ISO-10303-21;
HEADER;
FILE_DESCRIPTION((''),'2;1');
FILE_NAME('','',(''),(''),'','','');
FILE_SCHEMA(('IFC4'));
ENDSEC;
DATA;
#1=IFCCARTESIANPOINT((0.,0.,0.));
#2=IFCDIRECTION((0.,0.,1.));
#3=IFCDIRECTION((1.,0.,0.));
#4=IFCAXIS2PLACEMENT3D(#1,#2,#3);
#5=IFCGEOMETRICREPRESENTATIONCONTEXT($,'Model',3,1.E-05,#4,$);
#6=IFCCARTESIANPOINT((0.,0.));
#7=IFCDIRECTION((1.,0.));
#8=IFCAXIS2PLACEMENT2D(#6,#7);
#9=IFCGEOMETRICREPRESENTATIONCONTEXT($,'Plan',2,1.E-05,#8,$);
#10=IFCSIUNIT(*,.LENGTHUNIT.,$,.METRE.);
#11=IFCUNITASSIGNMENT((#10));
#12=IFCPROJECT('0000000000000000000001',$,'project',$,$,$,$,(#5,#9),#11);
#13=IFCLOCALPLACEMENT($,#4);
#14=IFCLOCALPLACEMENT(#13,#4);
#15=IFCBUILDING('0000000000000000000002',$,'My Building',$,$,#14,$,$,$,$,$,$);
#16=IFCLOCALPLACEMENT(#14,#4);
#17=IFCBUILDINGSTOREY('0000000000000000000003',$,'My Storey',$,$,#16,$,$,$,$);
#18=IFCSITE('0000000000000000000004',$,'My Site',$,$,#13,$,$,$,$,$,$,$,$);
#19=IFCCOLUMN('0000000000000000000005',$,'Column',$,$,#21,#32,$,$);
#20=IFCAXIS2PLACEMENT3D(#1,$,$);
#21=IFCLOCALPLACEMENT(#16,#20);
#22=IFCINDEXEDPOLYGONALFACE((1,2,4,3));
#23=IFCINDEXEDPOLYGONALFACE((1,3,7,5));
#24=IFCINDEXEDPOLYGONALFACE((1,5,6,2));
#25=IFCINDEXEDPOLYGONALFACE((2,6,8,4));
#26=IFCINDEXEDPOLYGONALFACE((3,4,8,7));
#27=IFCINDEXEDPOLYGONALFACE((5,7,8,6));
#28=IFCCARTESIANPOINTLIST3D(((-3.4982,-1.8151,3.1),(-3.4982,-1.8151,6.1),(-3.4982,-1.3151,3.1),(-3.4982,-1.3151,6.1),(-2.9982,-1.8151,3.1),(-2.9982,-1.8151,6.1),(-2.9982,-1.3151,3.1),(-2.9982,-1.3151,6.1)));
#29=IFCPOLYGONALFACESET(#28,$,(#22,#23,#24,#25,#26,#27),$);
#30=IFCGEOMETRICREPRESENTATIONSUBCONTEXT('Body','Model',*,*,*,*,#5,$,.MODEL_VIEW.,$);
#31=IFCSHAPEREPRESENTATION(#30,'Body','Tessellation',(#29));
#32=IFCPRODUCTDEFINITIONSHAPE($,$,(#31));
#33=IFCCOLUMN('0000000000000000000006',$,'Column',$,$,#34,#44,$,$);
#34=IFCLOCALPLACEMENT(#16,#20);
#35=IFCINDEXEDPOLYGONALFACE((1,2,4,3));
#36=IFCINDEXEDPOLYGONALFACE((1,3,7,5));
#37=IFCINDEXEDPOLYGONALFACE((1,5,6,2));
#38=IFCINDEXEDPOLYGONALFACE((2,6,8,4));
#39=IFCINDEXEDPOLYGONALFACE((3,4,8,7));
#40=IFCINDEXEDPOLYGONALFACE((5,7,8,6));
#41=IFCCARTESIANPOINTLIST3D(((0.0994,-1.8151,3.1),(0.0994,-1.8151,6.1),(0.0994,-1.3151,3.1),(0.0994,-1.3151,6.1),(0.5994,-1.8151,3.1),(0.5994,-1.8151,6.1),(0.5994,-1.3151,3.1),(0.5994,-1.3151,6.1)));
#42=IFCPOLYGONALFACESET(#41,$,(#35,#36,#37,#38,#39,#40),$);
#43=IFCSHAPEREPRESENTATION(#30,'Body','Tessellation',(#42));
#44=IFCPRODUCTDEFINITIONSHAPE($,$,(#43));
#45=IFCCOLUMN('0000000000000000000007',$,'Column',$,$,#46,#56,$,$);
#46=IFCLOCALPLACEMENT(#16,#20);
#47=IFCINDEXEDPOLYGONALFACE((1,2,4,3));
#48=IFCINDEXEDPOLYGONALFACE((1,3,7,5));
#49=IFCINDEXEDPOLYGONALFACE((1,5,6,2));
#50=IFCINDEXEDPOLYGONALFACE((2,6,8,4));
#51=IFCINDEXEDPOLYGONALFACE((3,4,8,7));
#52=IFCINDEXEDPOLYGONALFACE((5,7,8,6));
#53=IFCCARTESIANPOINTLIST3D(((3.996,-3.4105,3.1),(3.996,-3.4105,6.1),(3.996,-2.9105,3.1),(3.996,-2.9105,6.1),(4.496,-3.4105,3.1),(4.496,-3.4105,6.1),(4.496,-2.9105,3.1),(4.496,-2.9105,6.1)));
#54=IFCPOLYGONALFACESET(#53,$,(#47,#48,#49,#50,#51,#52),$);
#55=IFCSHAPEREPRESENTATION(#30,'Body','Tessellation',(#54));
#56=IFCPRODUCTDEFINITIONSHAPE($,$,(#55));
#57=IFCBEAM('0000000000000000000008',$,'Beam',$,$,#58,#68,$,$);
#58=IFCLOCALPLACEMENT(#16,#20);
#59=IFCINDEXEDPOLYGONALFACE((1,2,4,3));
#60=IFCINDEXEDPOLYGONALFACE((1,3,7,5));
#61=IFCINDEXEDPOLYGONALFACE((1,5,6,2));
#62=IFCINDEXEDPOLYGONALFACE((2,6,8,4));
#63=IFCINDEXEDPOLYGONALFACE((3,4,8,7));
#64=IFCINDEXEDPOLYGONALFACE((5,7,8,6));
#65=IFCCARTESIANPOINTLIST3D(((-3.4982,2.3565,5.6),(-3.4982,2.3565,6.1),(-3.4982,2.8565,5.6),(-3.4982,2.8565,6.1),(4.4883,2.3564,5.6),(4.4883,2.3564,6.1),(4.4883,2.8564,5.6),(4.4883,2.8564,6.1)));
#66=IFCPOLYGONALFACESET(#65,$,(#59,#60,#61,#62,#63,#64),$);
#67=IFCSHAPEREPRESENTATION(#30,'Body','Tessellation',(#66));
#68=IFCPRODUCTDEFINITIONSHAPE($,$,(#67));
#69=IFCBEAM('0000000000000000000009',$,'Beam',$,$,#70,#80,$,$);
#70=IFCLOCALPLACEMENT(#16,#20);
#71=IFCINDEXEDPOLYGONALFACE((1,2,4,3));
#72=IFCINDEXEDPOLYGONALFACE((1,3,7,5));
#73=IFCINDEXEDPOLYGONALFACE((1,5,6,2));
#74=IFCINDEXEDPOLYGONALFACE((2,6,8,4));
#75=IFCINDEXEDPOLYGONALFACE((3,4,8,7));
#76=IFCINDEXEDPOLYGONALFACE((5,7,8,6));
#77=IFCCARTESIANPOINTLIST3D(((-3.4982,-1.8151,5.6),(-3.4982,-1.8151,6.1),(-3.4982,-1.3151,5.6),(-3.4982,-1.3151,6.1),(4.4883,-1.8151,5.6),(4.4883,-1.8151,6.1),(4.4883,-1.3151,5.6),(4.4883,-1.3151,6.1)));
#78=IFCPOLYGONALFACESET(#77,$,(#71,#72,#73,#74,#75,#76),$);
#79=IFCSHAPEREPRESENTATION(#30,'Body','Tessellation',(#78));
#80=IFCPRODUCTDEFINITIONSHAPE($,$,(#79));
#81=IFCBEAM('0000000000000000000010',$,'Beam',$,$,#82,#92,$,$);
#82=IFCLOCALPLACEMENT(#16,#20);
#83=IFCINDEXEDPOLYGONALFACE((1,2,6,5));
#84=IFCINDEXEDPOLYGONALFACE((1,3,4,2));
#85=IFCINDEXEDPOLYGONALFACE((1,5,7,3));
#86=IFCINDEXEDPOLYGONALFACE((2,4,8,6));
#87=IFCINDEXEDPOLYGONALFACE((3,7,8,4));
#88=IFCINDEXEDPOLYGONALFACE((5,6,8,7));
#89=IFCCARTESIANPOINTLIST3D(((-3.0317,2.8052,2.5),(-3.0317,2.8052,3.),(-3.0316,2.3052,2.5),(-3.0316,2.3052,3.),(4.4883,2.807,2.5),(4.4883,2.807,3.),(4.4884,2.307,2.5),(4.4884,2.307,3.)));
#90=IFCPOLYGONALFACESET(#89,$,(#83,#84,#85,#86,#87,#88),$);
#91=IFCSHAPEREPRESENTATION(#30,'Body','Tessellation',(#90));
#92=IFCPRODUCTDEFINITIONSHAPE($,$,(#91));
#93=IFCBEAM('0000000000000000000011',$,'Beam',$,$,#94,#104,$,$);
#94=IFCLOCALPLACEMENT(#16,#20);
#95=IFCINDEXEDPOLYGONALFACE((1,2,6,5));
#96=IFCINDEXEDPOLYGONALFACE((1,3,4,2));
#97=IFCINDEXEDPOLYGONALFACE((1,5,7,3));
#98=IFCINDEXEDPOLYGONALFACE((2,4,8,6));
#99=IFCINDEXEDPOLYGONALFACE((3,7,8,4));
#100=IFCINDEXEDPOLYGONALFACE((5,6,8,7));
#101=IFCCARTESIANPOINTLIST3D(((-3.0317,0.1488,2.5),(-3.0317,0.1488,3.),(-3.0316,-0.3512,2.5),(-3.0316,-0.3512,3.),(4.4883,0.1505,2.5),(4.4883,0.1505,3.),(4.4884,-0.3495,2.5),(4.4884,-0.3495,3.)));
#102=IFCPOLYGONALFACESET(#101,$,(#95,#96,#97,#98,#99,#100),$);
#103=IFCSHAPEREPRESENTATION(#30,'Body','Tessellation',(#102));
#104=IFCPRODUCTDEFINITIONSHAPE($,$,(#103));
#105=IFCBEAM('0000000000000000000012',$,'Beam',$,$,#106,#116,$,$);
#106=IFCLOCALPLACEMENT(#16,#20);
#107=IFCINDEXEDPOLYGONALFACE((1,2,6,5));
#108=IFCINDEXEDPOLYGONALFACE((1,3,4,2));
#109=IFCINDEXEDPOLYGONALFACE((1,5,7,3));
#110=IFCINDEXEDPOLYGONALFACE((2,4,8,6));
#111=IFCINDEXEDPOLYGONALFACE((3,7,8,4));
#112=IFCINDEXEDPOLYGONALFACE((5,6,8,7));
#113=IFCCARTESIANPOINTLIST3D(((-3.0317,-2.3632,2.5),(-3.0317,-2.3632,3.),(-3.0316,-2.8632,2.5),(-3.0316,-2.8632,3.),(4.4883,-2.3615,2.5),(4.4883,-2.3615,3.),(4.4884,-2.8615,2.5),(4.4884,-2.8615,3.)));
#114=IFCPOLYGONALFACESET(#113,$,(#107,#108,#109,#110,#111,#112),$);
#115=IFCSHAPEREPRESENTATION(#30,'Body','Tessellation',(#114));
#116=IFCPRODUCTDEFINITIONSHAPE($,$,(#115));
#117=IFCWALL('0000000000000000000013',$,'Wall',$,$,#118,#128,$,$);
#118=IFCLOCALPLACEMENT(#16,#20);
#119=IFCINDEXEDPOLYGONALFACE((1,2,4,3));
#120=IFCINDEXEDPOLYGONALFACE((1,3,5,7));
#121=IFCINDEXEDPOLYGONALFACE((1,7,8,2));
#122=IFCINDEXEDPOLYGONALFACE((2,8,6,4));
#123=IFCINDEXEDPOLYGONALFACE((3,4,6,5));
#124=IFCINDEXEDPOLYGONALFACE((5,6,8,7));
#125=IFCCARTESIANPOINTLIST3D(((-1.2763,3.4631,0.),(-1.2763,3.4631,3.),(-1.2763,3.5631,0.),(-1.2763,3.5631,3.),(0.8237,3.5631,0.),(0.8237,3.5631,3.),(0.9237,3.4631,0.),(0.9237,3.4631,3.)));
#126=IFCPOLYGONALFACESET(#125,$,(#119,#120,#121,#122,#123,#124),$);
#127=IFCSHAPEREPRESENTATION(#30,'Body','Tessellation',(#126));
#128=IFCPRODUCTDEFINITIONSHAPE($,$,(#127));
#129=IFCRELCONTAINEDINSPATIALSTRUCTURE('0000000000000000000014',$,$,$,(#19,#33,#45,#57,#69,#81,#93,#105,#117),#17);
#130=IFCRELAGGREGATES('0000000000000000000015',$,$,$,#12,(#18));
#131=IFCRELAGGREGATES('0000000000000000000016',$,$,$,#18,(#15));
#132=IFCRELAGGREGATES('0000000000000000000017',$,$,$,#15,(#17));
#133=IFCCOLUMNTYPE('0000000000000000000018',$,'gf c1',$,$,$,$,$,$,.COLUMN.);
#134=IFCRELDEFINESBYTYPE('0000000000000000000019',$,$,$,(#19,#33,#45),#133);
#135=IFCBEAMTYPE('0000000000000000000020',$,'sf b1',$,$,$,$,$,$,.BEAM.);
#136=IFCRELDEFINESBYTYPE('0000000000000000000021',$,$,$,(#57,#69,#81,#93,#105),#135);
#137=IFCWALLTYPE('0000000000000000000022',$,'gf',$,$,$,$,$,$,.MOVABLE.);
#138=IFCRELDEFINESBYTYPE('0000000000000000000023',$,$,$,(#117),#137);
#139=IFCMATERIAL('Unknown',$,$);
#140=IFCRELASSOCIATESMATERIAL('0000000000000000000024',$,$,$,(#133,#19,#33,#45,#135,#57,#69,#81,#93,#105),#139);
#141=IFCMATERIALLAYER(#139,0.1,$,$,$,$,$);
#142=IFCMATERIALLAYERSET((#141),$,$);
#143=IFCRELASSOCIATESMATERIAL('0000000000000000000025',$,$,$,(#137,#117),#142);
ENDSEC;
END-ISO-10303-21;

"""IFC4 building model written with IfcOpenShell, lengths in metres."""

from ifc_helpers import new_model, si_unit, frame, origin_with_axes, origin_2d_with_axis, place, context, subcontext, project, spatial, line, indexed_curve, rectangle, outline, extrude, material, layer, layer_set, layer_usage, material_profile, profile_set, profile_usage, type_object, element, save


model = new_model("IFC4")

# Units and contexts
model_context = context("Model", 3, precision=1e-05, world=origin_with_axes())
plan_context = context("Plan", 2, precision=1e-05, world=origin_2d_with_axis())
body_context = subcontext(model_context, "Body", "Model", "MODEL_VIEW")
ifc_project = project(units=[si_unit("LENGTHUNIT", "METRE")], contexts=[model_context, plan_context])

# Site, building, storey
site_placement = place(None, origin_with_axes())
site = spatial("IfcSite", under=ifc_project, at=site_placement, Name="My Site")
building_placement = place(site_placement, origin_with_axes())
building = spatial("IfcBuilding", under=site, at=building_placement, Name="My Building")
storey_placement = place(building_placement, origin_with_axes())
storey = spatial("IfcBuildingStorey", under=building, at=storey_placement, Name="My Storey")

# Columns
ifc_material = material(Name="Unknown")
ifc_material_profile_1 = material_profile(ifc_material, rectangle(XDim=0.5, YDim=0.5))
ifc_profile_set_1 = profile_set([ifc_material_profile_1])
column_type_1 = type_object("IfcColumnType", Name="gf c1", PredefinedType="COLUMN", material=ifc_profile_set_1)
ifc_profile_usage_1 = profile_usage(ifc_profile_set_1, cardinal=5)
column_1_placement = place(storey_placement, frame((-3.2482, -1.5651, 3.1), z_axis=(0.0, 0.0, 1.0), x_axis=(1.0, 0.0, 0.0)))
element("IfcColumn", 1, at=column_1_placement, inside=storey, type_object=column_type_1, material=ifc_profile_usage_1, Name="Column", context=body_context, shape_type="SweptSolid", body=[
    extrude(rectangle(XDim=0.5, YDim=0.5), origin_with_axes(), (0.0, 0.0, 1.0), 3.0),
])
ifc_profile_usage_2 = profile_usage(ifc_profile_set_1, cardinal=5)
column_2_placement = place(storey_placement, frame((0.3494, -1.5651, 3.1), z_axis=(0.0, 0.0, 1.0), x_axis=(1.0, 0.0, 0.0)))
element("IfcColumn", 2, at=column_2_placement, inside=storey, type_object=column_type_1, material=ifc_profile_usage_2, Name="Column", context=body_context, shape_type="SweptSolid", body=[
    extrude(rectangle(XDim=0.5, YDim=0.5), origin_with_axes(), (0.0, 0.0, 1.0), 3.0),
])
ifc_profile_usage_3 = profile_usage(ifc_profile_set_1, cardinal=5)
column_3_placement = place(storey_placement, frame((4.246, -3.1605, 3.1), z_axis=(0.0, 0.0, 1.0), x_axis=(1.0, 0.0, 0.0)))
element("IfcColumn", 3, at=column_3_placement, inside=storey, type_object=column_type_1, material=ifc_profile_usage_3, Name="Column", context=body_context, shape_type="SweptSolid", body=[
    extrude(rectangle(XDim=0.5, YDim=0.5), origin_with_axes(), (0.0, 0.0, 1.0), 3.0),
])

# Beams
ifc_material_profile_2 = material_profile(ifc_material, rectangle(XDim=0.5, YDim=0.5))
ifc_profile_set_2 = profile_set([ifc_material_profile_2])
ifc_profile_usage_4 = profile_usage(ifc_profile_set_2, cardinal=7)
beam_type = type_object("IfcBeamType", Name="sf b1", PredefinedType="BEAM", material=ifc_profile_set_2)
beam_1_placement = place(storey_placement, frame((-3.4982, 2.8565, 6.1), z_axis=(1.0, -0.000001, 0.000001), x_axis=(0.000001, 1.0, 0.0)))
element("IfcBeam", 4, at=beam_1_placement, inside=storey, type_object=beam_type, material=ifc_profile_usage_4, Name="Beam", context=body_context, shape_type="SweptSolid", body=[
    extrude(rectangle(XDim=0.5, YDim=0.5), frame((-0.25, -0.25, 0.0), z_axis=(0.0, 0.0, 1.0), x_axis=(1.0, 0.0, 0.0)), (0.0, 0.0, 1.0), 7.9865),
])
ifc_profile_usage_5 = profile_usage(ifc_profile_set_2, cardinal=7)
beam_2_placement = place(storey_placement, frame((-3.4982, -1.3151, 6.1), z_axis=(1.0, -0.000001, 0.000001), x_axis=(0.000001, 1.0, 0.0)))
element("IfcBeam", 5, at=beam_2_placement, inside=storey, type_object=beam_type, material=ifc_profile_usage_5, Name="Beam", context=body_context, shape_type="SweptSolid", body=[
    extrude(rectangle(XDim=0.5, YDim=0.5), frame((-0.25, -0.25, 0.0), z_axis=(0.0, 0.0, 1.0), x_axis=(1.0, 0.0, 0.0)), (0.0, 0.0, 1.0), 7.9865),
])
ifc_profile_usage_6 = profile_usage(ifc_profile_set_2, cardinal=8)
beam_3_placement = place(storey_placement, frame((4.4883, 2.557, 3.0), z_axis=(-1.0, -0.000228, 0.0), x_axis=(0.000228, -1.0, 0.0)))
element("IfcBeam", 6, at=beam_3_placement, inside=storey, type_object=beam_type, material=ifc_profile_usage_6, Name="Beam", context=body_context, shape_type="SweptSolid", body=[
    extrude(rectangle(XDim=0.5, YDim=0.5), frame((0.0, -0.25, 0.0), z_axis=(0.0, 0.0, 1.0), x_axis=(1.0, 0.0, 0.0)), (0.0, 0.0, 1.0), 7.52),
])
ifc_profile_usage_7 = profile_usage(ifc_profile_set_2, cardinal=8)
beam_4_placement = place(storey_placement, frame((4.4883, -0.0995, 3.0), z_axis=(-1.0, -0.000228, 0.0), x_axis=(0.000228, -1.0, 0.0)))
element("IfcBeam", 7, at=beam_4_placement, inside=storey, type_object=beam_type, material=ifc_profile_usage_7, Name="Beam", context=body_context, shape_type="SweptSolid", body=[
    extrude(rectangle(XDim=0.5, YDim=0.5), frame((0.0, -0.25, 0.0), z_axis=(0.0, 0.0, 1.0), x_axis=(1.0, 0.0, 0.0)), (0.0, 0.0, 1.0), 7.52),
])
ifc_profile_usage_8 = profile_usage(ifc_profile_set_2, cardinal=8)
beam_5_placement = place(storey_placement, frame((4.4883, -2.6115, 3.0), z_axis=(-1.0, -0.000228, 0.0), x_axis=(0.000228, -1.0, 0.0)))
element("IfcBeam", 8, at=beam_5_placement, inside=storey, type_object=beam_type, material=ifc_profile_usage_8, Name="Beam", context=body_context, shape_type="SweptSolid", body=[
    extrude(rectangle(XDim=0.5, YDim=0.5), frame((0.0, -0.25, 0.0), z_axis=(0.0, 0.0, 1.0), x_axis=(1.0, 0.0, 0.0)), (0.0, 0.0, 1.0), 7.52),
])

# Wall
ifc_layer = layer(ifc_material, 0.1)
ifc_layer_set = layer_set([ifc_layer])
ifc_layer_usage = layer_usage(ifc_layer_set, "AXIS2", "POSITIVE", 0.0)
wall_type = type_object("IfcWallType", Name="gf", PredefinedType="MOVABLE", material=ifc_layer_set)
wall_placement = place(storey_placement, frame((-1.2763, 3.4631, 0.0), z_axis=(0.0, 0.0, 1.0), x_axis=(1.0, 0.0, 0.0)))
element("IfcWall", 9, at=wall_placement, inside=storey, type_object=wall_type, material=ifc_layer_usage, Name="Wall", context=body_context, shape_type="SweptSolid", body=[
    extrude(outline(indexed_curve([(0.0, 0.0), (0.0, 0.1), (2.1, 0.1), (2.2, 0.0)], segments=[line(1, 2, 3, 4, 1)])), origin_with_axes(), (0.0, 0.0, 1.0), 3.0),
])

save(model, "model.ifc")
